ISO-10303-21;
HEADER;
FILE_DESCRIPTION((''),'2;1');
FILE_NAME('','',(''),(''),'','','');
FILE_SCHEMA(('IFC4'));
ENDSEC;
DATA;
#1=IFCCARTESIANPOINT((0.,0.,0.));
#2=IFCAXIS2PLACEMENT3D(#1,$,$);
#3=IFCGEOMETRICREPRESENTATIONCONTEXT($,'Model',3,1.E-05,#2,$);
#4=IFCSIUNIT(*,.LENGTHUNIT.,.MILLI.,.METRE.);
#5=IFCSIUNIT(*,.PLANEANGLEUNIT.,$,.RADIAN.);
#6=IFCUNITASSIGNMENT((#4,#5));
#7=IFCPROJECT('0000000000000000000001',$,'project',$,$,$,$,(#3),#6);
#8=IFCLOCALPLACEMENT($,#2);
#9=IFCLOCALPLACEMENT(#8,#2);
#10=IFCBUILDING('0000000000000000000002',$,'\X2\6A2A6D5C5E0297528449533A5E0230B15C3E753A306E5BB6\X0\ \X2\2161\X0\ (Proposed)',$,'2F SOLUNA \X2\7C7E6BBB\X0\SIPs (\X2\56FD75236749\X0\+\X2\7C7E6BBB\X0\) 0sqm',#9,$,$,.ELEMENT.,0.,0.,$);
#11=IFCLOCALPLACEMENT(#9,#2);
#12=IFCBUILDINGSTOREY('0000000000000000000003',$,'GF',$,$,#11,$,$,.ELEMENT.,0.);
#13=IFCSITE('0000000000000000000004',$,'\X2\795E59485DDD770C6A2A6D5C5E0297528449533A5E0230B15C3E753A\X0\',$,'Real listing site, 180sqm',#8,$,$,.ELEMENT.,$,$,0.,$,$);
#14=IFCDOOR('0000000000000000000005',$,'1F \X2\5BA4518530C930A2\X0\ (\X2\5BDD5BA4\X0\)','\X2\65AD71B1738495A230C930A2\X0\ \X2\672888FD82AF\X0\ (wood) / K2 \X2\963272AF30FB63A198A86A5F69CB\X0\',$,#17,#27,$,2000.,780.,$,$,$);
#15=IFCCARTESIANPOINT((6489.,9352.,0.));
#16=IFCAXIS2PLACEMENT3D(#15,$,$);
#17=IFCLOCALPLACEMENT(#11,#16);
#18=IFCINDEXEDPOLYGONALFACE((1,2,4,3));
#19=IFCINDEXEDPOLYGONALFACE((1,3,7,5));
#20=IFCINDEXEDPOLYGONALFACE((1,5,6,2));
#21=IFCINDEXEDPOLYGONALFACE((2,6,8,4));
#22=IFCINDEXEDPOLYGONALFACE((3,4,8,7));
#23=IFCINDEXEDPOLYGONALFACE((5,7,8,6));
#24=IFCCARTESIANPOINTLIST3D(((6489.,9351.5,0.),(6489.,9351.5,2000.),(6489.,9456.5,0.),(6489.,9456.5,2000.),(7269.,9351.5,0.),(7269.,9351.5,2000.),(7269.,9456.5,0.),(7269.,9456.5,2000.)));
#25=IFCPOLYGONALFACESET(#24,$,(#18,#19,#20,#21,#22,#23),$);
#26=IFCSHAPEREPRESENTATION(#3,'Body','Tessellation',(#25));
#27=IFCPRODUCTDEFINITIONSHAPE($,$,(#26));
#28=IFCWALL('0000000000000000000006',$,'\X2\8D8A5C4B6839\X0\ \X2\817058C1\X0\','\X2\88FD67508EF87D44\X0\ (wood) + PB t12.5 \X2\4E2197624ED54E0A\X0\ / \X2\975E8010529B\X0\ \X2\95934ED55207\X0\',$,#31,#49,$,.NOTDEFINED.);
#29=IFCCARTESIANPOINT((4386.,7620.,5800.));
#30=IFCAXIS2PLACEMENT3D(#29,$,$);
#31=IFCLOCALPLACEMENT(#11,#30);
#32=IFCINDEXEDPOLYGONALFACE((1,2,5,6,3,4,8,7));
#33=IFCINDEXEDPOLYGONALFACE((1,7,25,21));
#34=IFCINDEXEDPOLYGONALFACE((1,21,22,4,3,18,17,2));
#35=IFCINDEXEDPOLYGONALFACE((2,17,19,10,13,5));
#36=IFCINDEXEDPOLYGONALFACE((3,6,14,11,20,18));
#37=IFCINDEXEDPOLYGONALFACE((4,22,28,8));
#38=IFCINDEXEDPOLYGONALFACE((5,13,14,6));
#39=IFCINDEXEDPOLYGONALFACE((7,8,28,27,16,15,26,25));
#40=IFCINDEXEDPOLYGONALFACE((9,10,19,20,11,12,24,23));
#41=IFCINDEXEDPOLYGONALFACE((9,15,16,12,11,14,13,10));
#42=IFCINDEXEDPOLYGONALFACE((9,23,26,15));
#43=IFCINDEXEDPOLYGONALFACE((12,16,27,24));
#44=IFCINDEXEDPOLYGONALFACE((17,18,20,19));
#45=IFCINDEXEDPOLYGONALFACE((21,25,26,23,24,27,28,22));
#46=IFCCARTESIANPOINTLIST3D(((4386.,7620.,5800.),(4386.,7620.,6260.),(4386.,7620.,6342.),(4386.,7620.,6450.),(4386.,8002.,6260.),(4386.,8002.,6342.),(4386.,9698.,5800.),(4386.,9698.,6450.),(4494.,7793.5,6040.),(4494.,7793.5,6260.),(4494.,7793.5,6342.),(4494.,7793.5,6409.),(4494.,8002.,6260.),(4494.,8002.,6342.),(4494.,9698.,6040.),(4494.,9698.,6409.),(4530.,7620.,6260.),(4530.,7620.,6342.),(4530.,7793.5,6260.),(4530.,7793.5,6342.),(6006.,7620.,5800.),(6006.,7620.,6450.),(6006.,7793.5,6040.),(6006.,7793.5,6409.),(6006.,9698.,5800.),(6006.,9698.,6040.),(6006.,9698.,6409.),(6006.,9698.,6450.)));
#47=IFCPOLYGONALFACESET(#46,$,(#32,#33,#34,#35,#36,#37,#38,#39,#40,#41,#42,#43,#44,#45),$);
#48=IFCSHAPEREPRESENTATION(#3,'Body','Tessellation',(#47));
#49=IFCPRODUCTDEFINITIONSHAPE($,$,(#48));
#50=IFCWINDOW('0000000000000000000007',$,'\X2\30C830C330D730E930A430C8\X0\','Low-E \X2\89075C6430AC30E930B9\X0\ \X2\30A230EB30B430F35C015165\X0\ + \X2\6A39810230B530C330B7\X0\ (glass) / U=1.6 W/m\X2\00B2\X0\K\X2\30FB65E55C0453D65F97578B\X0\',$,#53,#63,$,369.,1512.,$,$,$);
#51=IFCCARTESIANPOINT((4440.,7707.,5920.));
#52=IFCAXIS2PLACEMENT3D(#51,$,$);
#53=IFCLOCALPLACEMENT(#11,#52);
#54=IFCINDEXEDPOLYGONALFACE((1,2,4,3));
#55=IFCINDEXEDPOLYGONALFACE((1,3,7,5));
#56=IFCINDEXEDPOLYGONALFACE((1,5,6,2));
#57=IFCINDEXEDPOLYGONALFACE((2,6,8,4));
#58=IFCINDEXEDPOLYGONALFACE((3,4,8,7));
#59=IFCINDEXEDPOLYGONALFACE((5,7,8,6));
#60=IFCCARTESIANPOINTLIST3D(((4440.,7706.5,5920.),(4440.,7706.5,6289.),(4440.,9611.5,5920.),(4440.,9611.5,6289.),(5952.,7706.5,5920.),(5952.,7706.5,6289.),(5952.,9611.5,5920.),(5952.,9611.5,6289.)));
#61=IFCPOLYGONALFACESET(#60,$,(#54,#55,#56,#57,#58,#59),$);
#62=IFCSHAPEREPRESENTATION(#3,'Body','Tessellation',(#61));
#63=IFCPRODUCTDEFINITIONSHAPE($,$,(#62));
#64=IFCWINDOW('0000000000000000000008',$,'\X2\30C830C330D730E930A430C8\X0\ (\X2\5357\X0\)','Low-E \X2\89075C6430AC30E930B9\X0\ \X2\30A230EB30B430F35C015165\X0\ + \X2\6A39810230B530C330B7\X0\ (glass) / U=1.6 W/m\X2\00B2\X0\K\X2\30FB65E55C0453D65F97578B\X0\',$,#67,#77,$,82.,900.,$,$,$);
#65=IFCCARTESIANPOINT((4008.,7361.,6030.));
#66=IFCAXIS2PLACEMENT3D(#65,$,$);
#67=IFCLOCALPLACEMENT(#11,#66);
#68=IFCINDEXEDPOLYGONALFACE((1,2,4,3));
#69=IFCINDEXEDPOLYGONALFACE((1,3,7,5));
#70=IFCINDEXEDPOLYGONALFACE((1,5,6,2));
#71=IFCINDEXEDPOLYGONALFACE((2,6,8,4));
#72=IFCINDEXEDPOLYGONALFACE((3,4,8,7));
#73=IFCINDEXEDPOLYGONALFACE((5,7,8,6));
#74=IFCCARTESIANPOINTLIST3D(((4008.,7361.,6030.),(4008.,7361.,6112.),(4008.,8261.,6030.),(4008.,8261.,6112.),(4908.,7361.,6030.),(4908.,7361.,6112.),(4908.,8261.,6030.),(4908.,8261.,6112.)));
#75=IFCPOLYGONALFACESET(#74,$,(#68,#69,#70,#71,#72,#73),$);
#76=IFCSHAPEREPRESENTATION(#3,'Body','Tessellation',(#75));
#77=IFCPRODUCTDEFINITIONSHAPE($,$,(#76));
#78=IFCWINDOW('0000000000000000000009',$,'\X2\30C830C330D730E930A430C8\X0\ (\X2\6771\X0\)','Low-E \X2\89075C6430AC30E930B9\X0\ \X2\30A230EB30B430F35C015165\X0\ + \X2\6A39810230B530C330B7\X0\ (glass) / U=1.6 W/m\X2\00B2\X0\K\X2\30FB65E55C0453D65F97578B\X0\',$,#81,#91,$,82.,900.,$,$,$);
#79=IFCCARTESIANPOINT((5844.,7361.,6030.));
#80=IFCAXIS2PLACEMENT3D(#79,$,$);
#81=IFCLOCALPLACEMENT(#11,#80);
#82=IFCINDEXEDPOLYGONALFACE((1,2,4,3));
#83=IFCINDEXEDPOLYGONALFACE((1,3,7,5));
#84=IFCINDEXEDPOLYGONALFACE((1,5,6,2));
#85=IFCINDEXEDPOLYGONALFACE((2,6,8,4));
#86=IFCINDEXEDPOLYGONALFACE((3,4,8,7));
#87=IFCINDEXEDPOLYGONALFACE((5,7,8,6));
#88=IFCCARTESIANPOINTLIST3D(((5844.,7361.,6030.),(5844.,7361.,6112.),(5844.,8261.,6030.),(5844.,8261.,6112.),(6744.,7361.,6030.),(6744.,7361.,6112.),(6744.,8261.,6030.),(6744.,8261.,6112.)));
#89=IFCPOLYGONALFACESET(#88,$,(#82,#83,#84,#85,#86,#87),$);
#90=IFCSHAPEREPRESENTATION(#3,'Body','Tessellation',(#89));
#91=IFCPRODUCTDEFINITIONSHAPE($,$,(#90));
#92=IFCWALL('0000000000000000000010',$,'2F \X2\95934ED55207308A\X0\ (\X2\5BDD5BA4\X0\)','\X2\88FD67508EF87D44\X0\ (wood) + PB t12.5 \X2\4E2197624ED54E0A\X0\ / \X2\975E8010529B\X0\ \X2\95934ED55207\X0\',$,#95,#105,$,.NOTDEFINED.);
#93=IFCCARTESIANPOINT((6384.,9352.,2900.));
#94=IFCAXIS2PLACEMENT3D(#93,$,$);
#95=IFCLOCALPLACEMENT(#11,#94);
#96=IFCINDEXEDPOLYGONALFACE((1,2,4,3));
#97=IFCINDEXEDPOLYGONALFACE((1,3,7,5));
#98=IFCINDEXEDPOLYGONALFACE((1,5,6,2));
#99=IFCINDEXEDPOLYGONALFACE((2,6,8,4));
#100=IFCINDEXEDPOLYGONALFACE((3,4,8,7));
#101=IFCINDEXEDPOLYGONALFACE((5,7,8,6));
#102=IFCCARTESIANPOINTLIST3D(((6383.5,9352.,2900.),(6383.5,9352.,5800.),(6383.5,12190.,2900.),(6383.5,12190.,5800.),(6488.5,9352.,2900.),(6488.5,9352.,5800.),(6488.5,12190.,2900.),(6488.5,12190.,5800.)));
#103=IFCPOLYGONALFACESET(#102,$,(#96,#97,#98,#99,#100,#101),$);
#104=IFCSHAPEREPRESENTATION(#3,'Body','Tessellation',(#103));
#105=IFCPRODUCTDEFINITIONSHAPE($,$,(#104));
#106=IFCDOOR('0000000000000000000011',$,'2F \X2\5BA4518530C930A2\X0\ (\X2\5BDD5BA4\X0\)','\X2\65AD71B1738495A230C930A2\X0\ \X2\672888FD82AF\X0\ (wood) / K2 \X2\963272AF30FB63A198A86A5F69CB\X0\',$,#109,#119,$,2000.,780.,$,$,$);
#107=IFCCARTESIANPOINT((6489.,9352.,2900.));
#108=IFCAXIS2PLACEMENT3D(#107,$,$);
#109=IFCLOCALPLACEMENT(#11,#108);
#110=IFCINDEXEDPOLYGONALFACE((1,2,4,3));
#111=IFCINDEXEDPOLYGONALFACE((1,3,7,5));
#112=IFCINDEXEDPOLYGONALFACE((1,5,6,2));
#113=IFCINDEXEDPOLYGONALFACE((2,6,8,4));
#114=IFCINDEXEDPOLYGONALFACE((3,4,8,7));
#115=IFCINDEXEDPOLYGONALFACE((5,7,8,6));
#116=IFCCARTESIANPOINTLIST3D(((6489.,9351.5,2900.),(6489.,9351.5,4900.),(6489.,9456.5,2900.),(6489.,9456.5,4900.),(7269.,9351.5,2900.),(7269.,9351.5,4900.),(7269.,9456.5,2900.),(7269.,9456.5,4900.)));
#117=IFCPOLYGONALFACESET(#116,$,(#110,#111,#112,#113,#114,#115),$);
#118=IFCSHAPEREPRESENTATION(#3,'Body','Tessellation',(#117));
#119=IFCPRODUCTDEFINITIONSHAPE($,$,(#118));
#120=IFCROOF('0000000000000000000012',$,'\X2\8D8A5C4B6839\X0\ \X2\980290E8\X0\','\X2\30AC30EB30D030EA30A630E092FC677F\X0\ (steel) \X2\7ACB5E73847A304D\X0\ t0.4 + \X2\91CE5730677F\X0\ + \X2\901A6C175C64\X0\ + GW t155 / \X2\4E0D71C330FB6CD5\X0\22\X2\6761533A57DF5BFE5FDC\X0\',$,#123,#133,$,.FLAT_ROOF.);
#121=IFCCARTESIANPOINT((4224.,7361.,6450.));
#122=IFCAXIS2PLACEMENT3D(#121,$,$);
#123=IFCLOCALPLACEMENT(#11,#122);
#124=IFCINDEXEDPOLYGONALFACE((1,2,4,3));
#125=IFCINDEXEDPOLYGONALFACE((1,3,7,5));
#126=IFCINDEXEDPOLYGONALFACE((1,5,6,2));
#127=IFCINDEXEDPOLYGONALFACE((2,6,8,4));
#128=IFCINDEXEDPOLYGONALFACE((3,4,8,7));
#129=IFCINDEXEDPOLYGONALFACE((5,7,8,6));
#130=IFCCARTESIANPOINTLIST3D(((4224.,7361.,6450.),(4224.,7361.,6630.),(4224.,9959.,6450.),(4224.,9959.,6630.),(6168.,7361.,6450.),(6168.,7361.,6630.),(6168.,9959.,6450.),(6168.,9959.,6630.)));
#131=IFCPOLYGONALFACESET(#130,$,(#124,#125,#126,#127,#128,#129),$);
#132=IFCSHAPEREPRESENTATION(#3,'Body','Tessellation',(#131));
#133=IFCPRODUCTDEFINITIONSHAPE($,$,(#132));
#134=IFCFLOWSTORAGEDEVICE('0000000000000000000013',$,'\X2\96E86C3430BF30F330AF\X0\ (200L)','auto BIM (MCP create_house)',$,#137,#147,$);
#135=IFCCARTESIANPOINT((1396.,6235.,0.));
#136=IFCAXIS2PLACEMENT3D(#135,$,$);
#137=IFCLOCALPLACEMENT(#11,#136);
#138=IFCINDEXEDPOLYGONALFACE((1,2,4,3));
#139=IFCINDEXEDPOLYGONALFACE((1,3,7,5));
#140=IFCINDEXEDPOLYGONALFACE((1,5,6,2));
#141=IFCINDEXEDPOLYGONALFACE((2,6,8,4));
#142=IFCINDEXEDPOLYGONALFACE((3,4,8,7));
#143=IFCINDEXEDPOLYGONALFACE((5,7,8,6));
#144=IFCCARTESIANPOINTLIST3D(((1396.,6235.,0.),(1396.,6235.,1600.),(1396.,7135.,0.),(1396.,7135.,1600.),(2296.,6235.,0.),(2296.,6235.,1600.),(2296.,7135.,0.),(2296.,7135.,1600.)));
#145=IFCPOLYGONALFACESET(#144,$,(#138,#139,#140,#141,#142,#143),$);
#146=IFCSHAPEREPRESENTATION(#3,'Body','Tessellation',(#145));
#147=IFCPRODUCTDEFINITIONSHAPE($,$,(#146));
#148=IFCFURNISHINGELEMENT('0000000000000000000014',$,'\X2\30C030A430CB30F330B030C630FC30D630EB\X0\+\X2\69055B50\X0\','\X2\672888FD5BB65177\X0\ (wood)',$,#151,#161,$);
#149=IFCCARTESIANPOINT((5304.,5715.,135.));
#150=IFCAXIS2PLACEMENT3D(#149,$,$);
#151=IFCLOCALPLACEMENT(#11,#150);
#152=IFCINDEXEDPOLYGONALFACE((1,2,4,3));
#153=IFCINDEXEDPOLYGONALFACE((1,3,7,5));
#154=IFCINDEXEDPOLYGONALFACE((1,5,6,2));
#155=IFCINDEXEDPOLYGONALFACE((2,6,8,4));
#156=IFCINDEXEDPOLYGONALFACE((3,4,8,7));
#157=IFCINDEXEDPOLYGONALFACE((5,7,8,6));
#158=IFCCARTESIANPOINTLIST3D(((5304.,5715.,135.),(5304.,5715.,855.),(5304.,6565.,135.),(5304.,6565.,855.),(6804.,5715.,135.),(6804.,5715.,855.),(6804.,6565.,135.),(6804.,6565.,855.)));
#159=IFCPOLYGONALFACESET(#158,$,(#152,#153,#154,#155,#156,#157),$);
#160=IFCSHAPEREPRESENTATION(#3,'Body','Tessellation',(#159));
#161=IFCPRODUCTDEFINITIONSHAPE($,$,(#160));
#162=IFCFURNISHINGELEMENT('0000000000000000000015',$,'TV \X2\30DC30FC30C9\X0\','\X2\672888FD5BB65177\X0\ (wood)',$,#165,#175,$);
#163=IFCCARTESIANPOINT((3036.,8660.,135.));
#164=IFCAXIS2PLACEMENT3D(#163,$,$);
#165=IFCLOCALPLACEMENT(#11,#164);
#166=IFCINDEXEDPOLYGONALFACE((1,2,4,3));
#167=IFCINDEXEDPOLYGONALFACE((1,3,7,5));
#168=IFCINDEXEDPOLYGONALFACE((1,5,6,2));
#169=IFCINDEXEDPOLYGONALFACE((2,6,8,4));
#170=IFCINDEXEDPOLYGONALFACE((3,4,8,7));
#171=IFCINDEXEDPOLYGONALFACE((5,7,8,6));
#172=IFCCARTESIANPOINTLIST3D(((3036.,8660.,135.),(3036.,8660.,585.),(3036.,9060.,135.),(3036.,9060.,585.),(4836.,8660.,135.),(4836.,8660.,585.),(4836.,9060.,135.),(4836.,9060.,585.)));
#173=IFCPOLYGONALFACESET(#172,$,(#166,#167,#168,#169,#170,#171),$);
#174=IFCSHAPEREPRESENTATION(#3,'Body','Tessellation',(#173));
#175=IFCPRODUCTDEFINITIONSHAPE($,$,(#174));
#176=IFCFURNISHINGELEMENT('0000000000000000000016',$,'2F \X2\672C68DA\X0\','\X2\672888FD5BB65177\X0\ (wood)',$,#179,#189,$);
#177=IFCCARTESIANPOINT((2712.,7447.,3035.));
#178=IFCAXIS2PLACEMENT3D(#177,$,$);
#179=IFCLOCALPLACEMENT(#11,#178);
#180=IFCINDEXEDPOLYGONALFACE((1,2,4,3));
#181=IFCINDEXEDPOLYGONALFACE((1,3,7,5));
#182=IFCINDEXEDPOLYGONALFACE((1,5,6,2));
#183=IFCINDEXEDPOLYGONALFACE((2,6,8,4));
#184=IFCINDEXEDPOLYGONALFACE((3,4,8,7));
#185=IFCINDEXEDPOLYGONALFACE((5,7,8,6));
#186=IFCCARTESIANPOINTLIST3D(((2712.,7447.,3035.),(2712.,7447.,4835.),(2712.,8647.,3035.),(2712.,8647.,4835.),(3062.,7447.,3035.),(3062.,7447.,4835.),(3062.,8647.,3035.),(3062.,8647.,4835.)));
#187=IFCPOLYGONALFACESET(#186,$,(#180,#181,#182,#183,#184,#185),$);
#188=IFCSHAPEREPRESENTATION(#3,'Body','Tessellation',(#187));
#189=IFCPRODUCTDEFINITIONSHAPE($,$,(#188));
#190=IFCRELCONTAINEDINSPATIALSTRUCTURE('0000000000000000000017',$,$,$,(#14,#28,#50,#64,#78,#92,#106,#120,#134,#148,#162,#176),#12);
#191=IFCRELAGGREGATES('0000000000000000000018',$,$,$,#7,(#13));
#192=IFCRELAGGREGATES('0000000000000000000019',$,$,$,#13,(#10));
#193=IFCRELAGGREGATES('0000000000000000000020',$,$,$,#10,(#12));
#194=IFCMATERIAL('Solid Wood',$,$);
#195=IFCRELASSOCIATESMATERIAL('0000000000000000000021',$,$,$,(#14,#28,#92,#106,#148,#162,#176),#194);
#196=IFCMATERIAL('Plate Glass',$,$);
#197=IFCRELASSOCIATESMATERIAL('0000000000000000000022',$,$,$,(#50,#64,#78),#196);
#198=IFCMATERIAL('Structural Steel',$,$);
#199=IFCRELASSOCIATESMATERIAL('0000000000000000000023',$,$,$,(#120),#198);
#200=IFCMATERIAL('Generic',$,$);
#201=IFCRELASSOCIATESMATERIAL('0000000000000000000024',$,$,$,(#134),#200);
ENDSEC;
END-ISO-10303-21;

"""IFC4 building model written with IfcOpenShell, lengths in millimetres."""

from ifc_helpers import new_model, si_unit, frame, frame_2d, origin, place, context, project, spatial, rectangle, extrude, material, element, fill, save


model = new_model("IFC4")

# Units and contexts
model_context = context("Model", 3, precision=1e-05, world=origin())
ifc_project = project(units=[si_unit("LENGTHUNIT", "METRE", prefix="MILLI"), si_unit("PLANEANGLEUNIT", "RADIAN")], contexts=[model_context])

# Site, building, storey
site_placement = place(None, origin())
site = spatial("IfcSite", under=ifc_project, at=site_placement, Name="神奈川県横浜市青葉区市ケ尾町", ObjectType="Real listing site, 180sqm", CompositionType="ELEMENT", RefElevation=0.0)
building_placement = place(site_placement, origin())
building = spatial("IfcBuilding", under=site, at=building_placement, Name="横浜市青葉区市ケ尾町の家 Ⅱ (Proposed)", ObjectType="2F SOLUNA 籾殻SIPs (国産杉+籾殻) 0sqm", CompositionType="ELEMENT", ElevationOfRefHeight=0.0, ElevationOfTerrain=0.0)
storey_placement = place(building_placement, origin())
storey = spatial("IfcBuildingStorey", under=building, at=storey_placement, Name="GF", CompositionType="ELEMENT", Elevation=0.0)

# Shared definitions
ifc_material_1 = material(Name="Solid Wood")

# Door
door_1_placement = place(storey_placement, frame((6489.0, 9352.0, 0.0)))
element("IfcDoor", 1, at=door_1_placement, inside=storey, material=ifc_material_1, Name="1F 室内ドア (寝室)", Description="断熱玄関ドア 木製芯 (wood) / K2 防犯・採風機構", OverallHeight=2000.0, OverallWidth=780.0, context=model_context, shape_type="SweptSolid", body=[
    extrude(rectangle(XDim=780.0, YDim=105.0, at=frame_2d((390.0, 52.0))), frame((6489.0, 9352.0, 0.0)), (0.0, 0.0, 1.0), 2000.0),
])

# Wall, openings, windows
wall_1_placement = place(storey_placement, frame((4386.0, 7620.0, 5800.0)))
wall_1 = element("IfcWall", 2, at=wall_1_placement, inside=storey, material=ifc_material_1, Name="越屋根 腰壁", Description="製材軸組 (wood) + PB t12.5 両面仕上 / 非耐力 間仕切", PredefinedType="NOTDEFINED", context=model_context, shape_type="SweptSolid", body=[
    extrude(rectangle(XDim=1620.0, YDim=2078.0, at=frame_2d((810.0, 1039.0))), frame((4386.0, 7620.0, 5800.0)), (0.0, 0.0, 1.0), 650.0),
])
opening_1_placement = place(storey_placement, frame((4440.0, 7707.0, 5920.0)))
opening_1 = element("IfcOpeningElement", 3, at=opening_1_placement, cuts=wall_1, PredefinedType="NOTDEFINED", context=model_context, shape_type="SweptSolid", body=[
    extrude(rectangle(XDim=1512.0, YDim=1905.0, at=frame_2d((756.0, 952.0))), frame((4440.0, 7707.0, 5920.0)), (0.0, 0.0, 1.0), 369.0),
])
opening_2_placement = place(storey_placement, frame((4008.0, 7361.0, 6030.0)))
opening_2 = element("IfcOpeningElement", 4, at=opening_2_placement, cuts=wall_1, PredefinedType="NOTDEFINED", context=model_context, shape_type="SweptSolid", body=[
    extrude(rectangle(XDim=900.0, YDim=900.0, at=frame_2d((450.0, 450.0))), frame((4008.0, 7361.0, 6030.0)), (0.0, 0.0, 1.0), 82.0),
])
opening_3_placement = place(storey_placement, frame((5844.0, 7361.0, 6030.0)))
opening_3 = element("IfcOpeningElement", 5, at=opening_3_placement, cuts=wall_1, PredefinedType="NOTDEFINED", context=model_context, shape_type="SweptSolid", body=[
    extrude(rectangle(XDim=900.0, YDim=900.0, at=frame_2d((450.0, 450.0))), frame((5844.0, 7361.0, 6030.0)), (0.0, 0.0, 1.0), 82.0),
])
ifc_material_2 = material(Name="Plate Glass")
window_1_placement = place(storey_placement, frame((4440.0, 7707.0, 5920.0)))
window_1 = element("IfcWindow", 6, at=window_1_placement, inside=storey, material=ifc_material_2, Name="トップライト", Description="Low-E 複層ガラス アルゴン封入 + 樹脂サッシ (glass) / U=1.6 W/m²K・日射取得型", OverallHeight=369.0, OverallWidth=1512.0, context=model_context, shape_type="SweptSolid", body=[
    extrude(rectangle(XDim=1512.0, YDim=1905.0, at=frame_2d((756.0, 952.0))), frame((4440.0, 7707.0, 5920.0)), (0.0, 0.0, 1.0), 369.0),
])
fill(opening_1, window_1)
window_2_placement = place(storey_placement, frame((4008.0, 7361.0, 6030.0)))
window_2 = element("IfcWindow", 7, at=window_2_placement, inside=storey, material=ifc_material_2, Name="トップライト (南)", Description="Low-E 複層ガラス アルゴン封入 + 樹脂サッシ (glass) / U=1.6 W/m²K・日射取得型", OverallHeight=82.0, OverallWidth=900.0, context=model_context, shape_type="SweptSolid", body=[
    extrude(rectangle(XDim=900.0, YDim=900.0, at=frame_2d((450.0, 450.0))), frame((4008.0, 7361.0, 6030.0)), (0.0, 0.0, 1.0), 82.0),
])
fill(opening_2, window_2)
window_3_placement = place(storey_placement, frame((5844.0, 7361.0, 6030.0)))
window_3 = element("IfcWindow", 8, at=window_3_placement, inside=storey, material=ifc_material_2, Name="トップライト (東)", Description="Low-E 複層ガラス アルゴン封入 + 樹脂サッシ (glass) / U=1.6 W/m²K・日射取得型", OverallHeight=82.0, OverallWidth=900.0, context=model_context, shape_type="SweptSolid", body=[
    extrude(rectangle(XDim=900.0, YDim=900.0, at=frame_2d((450.0, 450.0))), frame((5844.0, 7361.0, 6030.0)), (0.0, 0.0, 1.0), 82.0),
])
fill(opening_3, window_3)

# Wall
wall_2_placement = place(storey_placement, frame((6384.0, 9352.0, 2900.0)))
element("IfcWall", 9, at=wall_2_placement, inside=storey, material=ifc_material_1, Name="2F 間仕切り (寝室)", Description="製材軸組 (wood) + PB t12.5 両面仕上 / 非耐力 間仕切", PredefinedType="NOTDEFINED", context=model_context, shape_type="SweptSolid", body=[
    extrude(rectangle(XDim=105.0, YDim=2838.0, at=frame_2d((52.0, 1419.0))), frame((6384.0, 9352.0, 2900.0)), (0.0, 0.0, 1.0), 2900.0),
])

# Door
door_2_placement = place(storey_placement, frame((6489.0, 9352.0, 2900.0)))
element("IfcDoor", 10, at=door_2_placement, inside=storey, material=ifc_material_1, Name="2F 室内ドア (寝室)", Description="断熱玄関ドア 木製芯 (wood) / K2 防犯・採風機構", OverallHeight=2000.0, OverallWidth=780.0, context=model_context, shape_type="SweptSolid", body=[
    extrude(rectangle(XDim=780.0, YDim=105.0, at=frame_2d((390.0, 52.0))), frame((6489.0, 9352.0, 2900.0)), (0.0, 0.0, 1.0), 2000.0),
])

# Roof
ifc_material_3 = material(Name="Structural Steel")
roof_placement = place(storey_placement, frame((4224.0, 7361.0, 6450.0)))
element("IfcRoof", 11, at=roof_placement, inside=storey, material=ifc_material_3, Name="越屋根 頂部", Description="ガルバリウム鋼板 (steel) 立平葺き t0.4 + 野地板 + 通気層 + GW t155 / 不燃・法22条区域対応", PredefinedType="FLAT_ROOF", context=model_context, shape_type="SweptSolid", body=[
    extrude(rectangle(XDim=1944.0, YDim=2598.0, at=frame_2d((972.0, 1299.0))), frame((4224.0, 7361.0, 6450.0)), (0.0, 0.0, 1.0), 180.0),
])

# Flow storage device
ifc_material_4 = material(Name="Generic")
flow_storage_device_placement = place(storey_placement, frame((1396.0, 6235.0, 0.0)))
element("IfcFlowStorageDevice", 12, at=flow_storage_device_placement, inside=storey, material=ifc_material_4, Name="雨水タンク (200L)", Description="auto BIM (MCP create_house)", context=model_context, shape_type="SweptSolid", body=[
    extrude(rectangle(XDim=900.0, YDim=900.0, at=frame_2d((450.0, 450.0))), frame((1396.0, 6235.0, 0.0)), (0.0, 0.0, 1.0), 1600.0),
])

# Furnishing elements
furnishing_1_placement = place(storey_placement, frame((5304.0, 5715.0, 135.0)))
element("IfcFurnishingElement", 13, at=furnishing_1_placement, inside=storey, material=ifc_material_1, Name="ダイニングテーブル+椅子", Description="木製家具 (wood)", context=model_context, shape_type="SweptSolid", body=[
    extrude(rectangle(XDim=1500.0, YDim=850.0, at=frame_2d((750.0, 425.0))), frame((5304.0, 5715.0, 135.0)), (0.0, 0.0, 1.0), 720.0),
])
furnishing_2_placement = place(storey_placement, frame((3036.0, 8660.0, 135.0)))
element("IfcFurnishingElement", 14, at=furnishing_2_placement, inside=storey, material=ifc_material_1, Name="TV ボード", Description="木製家具 (wood)", context=model_context, shape_type="SweptSolid", body=[
    extrude(rectangle(XDim=1800.0, YDim=400.0, at=frame_2d((900.0, 200.0))), frame((3036.0, 8660.0, 135.0)), (0.0, 0.0, 1.0), 450.0),
])
furnishing_3_placement = place(storey_placement, frame((2712.0, 7447.0, 3035.0)))
element("IfcFurnishingElement", 15, at=furnishing_3_placement, inside=storey, material=ifc_material_1, Name="2F 本棚", Description="木製家具 (wood)", context=model_context, shape_type="SweptSolid", body=[
    extrude(rectangle(XDim=350.0, YDim=1200.0, at=frame_2d((175.0, 600.0))), frame((2712.0, 7447.0, 3035.0)), (0.0, 0.0, 1.0), 1800.0),
])

save(model, "model.ifc")
